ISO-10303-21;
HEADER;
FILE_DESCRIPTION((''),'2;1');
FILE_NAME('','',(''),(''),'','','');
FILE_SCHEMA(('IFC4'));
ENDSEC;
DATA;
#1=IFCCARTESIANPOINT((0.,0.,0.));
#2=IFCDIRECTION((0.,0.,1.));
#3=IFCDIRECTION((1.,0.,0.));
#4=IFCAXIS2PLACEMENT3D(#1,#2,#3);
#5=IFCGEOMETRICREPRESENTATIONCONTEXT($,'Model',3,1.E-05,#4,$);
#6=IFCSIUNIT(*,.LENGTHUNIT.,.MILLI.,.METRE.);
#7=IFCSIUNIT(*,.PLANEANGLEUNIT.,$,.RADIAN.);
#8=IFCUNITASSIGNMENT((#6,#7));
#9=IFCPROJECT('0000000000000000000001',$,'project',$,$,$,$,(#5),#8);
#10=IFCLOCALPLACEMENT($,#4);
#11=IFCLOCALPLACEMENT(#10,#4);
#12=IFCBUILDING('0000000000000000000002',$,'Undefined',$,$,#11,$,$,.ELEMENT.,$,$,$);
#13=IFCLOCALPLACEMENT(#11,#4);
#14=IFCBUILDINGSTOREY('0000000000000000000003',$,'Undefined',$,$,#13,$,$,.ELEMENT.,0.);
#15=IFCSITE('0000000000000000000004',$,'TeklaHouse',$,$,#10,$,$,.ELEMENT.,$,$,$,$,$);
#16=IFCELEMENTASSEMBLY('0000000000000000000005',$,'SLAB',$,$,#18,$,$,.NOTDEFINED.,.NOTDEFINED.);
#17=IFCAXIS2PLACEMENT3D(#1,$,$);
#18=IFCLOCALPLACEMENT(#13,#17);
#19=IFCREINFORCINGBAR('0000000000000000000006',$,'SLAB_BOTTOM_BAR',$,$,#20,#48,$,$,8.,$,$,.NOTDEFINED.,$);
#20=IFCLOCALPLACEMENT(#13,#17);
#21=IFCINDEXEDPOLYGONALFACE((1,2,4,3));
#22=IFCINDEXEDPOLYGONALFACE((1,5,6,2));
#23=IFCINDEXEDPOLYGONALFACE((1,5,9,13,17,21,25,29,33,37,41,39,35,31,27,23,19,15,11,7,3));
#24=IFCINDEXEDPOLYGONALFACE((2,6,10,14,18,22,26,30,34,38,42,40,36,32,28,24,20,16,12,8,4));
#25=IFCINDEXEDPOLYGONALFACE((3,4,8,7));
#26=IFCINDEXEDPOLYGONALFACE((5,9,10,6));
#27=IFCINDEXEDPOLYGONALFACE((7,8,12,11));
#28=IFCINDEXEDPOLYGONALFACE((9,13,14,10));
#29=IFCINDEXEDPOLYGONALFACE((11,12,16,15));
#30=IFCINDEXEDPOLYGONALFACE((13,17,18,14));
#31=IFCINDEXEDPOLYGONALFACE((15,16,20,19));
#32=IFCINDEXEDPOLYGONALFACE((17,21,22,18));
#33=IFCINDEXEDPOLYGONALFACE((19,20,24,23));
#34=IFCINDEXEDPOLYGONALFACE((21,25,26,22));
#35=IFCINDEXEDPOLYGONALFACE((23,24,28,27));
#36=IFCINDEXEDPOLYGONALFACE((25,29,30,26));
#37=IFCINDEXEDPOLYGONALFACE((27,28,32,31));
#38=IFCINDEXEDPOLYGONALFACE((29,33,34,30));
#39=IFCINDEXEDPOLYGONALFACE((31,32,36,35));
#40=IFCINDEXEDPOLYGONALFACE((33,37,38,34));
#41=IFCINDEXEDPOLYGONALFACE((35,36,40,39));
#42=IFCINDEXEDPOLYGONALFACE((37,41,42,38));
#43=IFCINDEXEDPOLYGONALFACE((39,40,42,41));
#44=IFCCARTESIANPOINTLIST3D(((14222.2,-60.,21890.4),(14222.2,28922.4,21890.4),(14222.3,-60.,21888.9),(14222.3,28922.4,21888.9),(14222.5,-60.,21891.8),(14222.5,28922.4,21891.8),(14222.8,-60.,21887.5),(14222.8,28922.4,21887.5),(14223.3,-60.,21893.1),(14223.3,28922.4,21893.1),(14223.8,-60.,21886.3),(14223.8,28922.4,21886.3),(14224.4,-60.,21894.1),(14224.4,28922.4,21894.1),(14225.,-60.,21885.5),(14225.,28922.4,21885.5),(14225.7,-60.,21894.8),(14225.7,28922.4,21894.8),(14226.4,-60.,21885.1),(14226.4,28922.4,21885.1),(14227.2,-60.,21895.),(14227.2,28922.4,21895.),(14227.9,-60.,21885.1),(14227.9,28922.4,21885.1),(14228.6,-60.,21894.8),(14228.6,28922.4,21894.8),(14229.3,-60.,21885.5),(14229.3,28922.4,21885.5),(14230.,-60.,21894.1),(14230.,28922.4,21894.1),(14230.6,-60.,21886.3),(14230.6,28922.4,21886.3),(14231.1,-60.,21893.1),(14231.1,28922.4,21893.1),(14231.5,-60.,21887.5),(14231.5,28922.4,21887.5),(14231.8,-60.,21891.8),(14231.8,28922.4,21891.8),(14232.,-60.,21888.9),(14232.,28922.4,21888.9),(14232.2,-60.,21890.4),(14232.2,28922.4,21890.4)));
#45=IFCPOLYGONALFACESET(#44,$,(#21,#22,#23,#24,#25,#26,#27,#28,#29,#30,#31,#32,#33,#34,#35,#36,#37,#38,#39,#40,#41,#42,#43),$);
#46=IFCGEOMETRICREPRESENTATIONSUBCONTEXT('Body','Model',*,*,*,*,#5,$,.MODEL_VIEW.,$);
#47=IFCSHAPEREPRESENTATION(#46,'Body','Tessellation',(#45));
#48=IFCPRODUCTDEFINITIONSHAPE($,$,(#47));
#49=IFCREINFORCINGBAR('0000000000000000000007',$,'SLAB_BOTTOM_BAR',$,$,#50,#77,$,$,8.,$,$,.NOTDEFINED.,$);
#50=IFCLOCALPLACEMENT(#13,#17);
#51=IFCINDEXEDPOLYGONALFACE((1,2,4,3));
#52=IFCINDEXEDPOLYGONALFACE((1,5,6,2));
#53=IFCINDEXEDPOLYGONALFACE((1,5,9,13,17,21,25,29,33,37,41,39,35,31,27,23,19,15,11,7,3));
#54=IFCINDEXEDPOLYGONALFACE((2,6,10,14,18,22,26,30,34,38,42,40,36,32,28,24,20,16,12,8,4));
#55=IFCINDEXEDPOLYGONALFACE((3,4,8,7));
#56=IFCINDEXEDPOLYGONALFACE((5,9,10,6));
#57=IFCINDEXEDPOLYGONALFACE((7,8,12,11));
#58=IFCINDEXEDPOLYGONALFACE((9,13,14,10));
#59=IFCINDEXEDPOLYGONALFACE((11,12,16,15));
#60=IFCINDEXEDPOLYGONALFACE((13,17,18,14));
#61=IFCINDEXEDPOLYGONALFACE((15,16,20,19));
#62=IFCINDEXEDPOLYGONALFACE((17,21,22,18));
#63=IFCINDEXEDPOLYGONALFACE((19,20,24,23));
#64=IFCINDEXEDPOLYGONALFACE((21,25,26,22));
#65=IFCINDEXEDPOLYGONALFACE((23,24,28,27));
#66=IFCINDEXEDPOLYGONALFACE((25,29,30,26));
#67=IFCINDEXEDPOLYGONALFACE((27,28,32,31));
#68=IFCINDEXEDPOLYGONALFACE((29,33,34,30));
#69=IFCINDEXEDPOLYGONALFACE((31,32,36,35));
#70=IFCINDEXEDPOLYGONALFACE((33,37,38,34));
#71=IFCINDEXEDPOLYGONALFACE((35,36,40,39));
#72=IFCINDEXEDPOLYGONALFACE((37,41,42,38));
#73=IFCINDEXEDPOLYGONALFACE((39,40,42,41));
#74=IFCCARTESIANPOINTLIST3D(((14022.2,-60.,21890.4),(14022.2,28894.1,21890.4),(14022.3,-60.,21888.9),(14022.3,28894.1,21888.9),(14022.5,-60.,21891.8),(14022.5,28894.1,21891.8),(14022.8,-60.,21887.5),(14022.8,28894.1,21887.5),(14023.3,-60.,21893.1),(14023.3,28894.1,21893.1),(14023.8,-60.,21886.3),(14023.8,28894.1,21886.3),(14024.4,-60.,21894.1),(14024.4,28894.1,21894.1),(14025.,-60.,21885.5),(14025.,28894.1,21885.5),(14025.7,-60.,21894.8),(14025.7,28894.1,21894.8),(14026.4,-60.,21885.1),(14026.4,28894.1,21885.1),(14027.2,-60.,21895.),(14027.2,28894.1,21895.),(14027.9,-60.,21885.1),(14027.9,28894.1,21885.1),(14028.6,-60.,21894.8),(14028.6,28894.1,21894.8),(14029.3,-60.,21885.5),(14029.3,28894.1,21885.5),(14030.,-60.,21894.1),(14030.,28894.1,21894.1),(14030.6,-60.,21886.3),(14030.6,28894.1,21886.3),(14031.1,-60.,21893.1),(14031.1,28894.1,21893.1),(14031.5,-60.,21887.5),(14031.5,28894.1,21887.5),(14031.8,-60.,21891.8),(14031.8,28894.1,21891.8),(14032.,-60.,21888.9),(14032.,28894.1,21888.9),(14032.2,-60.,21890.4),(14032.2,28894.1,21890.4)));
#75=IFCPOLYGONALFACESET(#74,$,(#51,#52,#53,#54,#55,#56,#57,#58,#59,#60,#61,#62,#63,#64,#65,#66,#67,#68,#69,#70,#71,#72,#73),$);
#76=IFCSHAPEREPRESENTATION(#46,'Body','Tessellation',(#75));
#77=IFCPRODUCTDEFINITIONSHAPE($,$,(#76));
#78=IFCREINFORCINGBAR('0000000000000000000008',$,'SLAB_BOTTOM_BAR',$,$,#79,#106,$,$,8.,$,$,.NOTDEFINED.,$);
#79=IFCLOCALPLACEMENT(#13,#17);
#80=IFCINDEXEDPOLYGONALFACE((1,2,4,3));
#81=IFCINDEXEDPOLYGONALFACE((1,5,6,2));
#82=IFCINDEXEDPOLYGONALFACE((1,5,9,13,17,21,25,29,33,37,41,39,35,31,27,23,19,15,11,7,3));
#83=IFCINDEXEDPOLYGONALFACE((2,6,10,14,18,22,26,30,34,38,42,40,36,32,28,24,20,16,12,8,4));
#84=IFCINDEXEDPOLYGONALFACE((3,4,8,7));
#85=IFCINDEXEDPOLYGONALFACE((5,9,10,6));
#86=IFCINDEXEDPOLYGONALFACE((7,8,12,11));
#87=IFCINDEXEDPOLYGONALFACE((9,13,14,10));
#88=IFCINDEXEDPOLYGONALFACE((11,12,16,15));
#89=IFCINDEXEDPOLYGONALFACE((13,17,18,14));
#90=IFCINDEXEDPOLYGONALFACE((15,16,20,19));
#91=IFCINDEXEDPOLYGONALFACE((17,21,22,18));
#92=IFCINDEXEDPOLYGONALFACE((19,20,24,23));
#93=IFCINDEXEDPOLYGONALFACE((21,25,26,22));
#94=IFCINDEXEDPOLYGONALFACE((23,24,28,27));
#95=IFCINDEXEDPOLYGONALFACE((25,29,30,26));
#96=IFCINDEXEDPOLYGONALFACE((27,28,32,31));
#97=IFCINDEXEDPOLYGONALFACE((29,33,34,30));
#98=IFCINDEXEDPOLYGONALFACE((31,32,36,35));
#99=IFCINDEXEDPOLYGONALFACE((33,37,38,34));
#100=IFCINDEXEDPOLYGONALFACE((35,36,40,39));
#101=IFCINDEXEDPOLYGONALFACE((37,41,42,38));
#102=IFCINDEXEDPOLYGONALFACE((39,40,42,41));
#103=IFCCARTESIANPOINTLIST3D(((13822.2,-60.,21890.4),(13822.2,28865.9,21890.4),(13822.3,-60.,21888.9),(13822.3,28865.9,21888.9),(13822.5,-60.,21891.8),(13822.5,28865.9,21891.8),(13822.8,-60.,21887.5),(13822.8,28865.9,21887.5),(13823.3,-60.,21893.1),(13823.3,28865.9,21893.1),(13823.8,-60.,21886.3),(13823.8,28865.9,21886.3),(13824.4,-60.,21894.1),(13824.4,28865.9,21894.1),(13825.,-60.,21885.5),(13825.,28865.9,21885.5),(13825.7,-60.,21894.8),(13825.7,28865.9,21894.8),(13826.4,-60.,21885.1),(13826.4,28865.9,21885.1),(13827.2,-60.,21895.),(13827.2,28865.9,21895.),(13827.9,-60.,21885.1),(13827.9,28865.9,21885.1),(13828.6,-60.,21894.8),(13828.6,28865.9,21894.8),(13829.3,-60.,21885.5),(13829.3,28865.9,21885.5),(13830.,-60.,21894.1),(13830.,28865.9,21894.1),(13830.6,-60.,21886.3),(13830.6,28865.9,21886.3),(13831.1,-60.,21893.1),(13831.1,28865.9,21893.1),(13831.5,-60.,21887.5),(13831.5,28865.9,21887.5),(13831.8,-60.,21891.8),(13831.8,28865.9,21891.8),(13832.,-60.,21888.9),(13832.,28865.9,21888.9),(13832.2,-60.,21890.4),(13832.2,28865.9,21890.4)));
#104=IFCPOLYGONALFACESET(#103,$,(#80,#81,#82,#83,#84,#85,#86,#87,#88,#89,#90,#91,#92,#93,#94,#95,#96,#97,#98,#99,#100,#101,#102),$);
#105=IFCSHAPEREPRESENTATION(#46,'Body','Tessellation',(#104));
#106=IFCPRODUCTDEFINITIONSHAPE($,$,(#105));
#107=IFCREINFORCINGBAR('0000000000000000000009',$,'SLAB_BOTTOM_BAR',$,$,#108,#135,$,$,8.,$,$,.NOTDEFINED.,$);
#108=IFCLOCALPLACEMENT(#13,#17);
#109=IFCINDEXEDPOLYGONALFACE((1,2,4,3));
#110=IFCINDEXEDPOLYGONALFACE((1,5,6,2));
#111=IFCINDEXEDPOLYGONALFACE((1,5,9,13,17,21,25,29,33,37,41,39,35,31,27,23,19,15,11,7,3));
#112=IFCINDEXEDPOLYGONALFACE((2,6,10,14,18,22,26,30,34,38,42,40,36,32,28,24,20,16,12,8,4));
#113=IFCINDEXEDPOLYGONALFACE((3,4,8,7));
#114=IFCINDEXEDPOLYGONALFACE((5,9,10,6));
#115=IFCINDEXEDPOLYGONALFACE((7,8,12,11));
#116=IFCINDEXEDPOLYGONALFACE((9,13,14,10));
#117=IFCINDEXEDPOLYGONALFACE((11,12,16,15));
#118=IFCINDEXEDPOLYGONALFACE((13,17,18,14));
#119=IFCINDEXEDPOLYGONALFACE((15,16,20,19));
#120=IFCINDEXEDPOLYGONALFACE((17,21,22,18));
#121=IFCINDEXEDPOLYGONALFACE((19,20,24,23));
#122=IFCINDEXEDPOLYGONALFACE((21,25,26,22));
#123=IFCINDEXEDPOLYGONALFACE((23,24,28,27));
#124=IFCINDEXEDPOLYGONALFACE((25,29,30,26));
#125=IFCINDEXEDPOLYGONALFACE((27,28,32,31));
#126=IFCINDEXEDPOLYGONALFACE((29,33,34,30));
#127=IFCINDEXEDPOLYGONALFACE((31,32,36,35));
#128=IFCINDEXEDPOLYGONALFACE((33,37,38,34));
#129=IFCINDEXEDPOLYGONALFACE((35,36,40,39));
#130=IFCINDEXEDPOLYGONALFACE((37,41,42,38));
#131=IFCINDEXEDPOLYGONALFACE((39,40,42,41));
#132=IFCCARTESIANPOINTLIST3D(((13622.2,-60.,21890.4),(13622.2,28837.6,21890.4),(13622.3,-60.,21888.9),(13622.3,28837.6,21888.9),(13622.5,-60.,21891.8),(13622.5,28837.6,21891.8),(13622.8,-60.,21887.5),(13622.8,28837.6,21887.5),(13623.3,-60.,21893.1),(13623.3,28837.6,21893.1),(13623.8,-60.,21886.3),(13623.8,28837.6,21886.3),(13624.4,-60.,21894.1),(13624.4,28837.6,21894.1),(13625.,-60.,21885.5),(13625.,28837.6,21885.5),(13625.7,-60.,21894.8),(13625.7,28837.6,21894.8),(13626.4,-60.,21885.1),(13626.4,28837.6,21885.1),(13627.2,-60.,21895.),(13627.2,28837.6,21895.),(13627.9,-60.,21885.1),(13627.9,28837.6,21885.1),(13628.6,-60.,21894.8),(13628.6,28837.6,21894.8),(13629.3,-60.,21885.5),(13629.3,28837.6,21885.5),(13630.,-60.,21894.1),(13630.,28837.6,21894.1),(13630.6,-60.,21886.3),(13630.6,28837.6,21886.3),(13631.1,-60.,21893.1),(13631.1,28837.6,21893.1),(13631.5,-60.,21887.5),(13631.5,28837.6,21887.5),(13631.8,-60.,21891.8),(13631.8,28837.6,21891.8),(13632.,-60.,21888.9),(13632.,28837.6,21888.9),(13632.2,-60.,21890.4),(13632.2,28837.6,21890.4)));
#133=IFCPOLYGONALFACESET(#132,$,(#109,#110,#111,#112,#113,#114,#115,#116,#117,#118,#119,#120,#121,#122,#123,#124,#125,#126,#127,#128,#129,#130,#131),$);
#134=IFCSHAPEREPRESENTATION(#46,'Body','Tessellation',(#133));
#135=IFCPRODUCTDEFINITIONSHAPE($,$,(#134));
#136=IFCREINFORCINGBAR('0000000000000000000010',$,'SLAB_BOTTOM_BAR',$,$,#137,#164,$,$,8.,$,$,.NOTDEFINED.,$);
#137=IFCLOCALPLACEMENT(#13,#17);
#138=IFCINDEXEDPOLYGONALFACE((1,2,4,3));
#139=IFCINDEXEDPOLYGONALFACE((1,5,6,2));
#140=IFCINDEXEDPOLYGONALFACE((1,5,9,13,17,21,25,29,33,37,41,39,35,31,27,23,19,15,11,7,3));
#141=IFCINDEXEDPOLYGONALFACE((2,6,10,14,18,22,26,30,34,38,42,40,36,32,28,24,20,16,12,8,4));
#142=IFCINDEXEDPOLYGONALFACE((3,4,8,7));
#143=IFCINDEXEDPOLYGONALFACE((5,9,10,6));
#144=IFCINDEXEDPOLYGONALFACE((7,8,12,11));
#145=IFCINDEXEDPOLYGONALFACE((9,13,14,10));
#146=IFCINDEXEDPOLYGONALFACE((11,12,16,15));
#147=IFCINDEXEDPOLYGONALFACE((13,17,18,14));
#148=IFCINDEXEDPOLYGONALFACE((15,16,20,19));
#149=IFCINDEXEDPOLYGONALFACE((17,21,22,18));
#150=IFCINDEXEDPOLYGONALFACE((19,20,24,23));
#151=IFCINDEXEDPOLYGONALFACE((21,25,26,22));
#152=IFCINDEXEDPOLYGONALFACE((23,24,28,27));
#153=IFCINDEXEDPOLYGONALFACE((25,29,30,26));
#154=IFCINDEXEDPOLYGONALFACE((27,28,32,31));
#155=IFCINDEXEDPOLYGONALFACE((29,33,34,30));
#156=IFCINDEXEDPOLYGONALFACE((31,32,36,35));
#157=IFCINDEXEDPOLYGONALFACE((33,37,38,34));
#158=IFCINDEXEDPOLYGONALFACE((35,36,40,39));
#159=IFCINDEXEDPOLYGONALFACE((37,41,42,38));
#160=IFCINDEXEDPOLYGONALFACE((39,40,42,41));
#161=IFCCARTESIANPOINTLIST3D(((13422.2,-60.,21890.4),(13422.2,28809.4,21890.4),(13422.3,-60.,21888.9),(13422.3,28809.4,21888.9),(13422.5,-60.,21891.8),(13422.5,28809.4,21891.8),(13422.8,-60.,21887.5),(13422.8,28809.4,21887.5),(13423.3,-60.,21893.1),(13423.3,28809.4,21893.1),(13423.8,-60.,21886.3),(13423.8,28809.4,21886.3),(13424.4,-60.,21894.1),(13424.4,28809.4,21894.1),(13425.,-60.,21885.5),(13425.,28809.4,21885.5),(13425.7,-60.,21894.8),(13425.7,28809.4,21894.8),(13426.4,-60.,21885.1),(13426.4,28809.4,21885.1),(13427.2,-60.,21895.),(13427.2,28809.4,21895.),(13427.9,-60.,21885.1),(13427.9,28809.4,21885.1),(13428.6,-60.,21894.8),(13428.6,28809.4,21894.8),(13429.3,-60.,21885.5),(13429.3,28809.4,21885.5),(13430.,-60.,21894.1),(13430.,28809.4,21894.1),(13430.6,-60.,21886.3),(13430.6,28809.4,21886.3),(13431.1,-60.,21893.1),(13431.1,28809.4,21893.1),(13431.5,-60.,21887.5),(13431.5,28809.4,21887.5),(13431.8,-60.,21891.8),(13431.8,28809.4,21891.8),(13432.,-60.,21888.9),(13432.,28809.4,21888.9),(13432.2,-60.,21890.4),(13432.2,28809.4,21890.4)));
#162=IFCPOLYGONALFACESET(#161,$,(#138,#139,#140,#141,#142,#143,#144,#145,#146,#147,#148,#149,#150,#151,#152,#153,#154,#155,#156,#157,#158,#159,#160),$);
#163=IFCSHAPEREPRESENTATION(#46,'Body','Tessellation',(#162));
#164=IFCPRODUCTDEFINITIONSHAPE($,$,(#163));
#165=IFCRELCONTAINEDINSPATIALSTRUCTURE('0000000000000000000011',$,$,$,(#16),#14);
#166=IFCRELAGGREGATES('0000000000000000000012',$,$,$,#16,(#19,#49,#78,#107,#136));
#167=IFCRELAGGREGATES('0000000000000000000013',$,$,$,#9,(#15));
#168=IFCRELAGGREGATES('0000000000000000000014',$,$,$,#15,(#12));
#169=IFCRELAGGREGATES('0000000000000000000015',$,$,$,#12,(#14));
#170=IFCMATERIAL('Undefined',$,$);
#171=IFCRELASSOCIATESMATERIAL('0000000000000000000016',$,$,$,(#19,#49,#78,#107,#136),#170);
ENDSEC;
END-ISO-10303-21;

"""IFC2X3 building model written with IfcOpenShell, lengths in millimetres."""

from ifc_helpers import new_model, entity, si_unit, frame, origin_with_axes, place, context, subcontext, project, spatial, source, transform, mapped, material, element, aggregate, save


model = new_model("IFC2X3")

# Units and contexts
model_context = context("Model", 3, precision=1e-05, world=origin_with_axes())
body_context = subcontext(model_context, "Body", "Model", "MODEL_VIEW")
ifc_project = project(units=[si_unit("LENGTHUNIT", "METRE", prefix="MILLI"), si_unit("PLANEANGLEUNIT", "RADIAN")], contexts=[model_context])

# Site, building, storey
site_placement = place(None, origin_with_axes())
site = spatial("IfcSite", under=ifc_project, at=site_placement, Name="TeklaHouse", CompositionType="ELEMENT")
building_placement = place(site_placement, origin_with_axes())
building = spatial("IfcBuilding", under=site, at=building_placement, Name="Undefined", CompositionType="ELEMENT")
storey_placement = place(building_placement, origin_with_axes())
storey = spatial("IfcBuildingStorey", under=building, at=storey_placement, Name="Undefined", CompositionType="ELEMENT", Elevation=0.0)

# Shared definitions
ifc_material_1 = material(Name="Undefined")

# Element assembly, reinforcing bars
assembly_1_placement = place(storey_placement, origin_with_axes())
assembly_1 = element("IfcElementAssembly", 1, at=assembly_1_placement, inside=storey, Name="SLAB", AssemblyPlace="NOTDEFINED", PredefinedType="NOTDEFINED")
shared_shape_1 = source(origin_with_axes(), body_context, "Body", "AdvancedSweptSolid", [
    entity("IfcSweptDiskSolid", entity("IfcTrimmedCurve", entity("IfcLine", entity("IfcCartesianPoint", [0.0, 0.0, 0.0]), entity("IfcVector", entity("IfcDirection", [1.0, 0.0, 0.0]), 1.0)), [entity("IfcParameterValue", 0.0)], [entity("IfcParameterValue", 28982.363359)], True, "PARAMETER"), 5.0, None, 0.0, 28982.4),
])
reinforcing_bar_1_placement = place(assembly_1_placement, frame((14227.2, -60.0, 21890.0), z_axis=(0.0, 0.0, 1.0), x_axis=(0.0, 1.0, 0.0)))
reinforcing_bar_1 = element("IfcReinforcingBar", 2, at=reinforcing_bar_1_placement, material=ifc_material_1, Name="SLAB_BOTTOM_BAR", BarRole="NOTDEFINED", NominalDiameter=8.0, context=body_context, shape_type="MappedRepresentation", body=[
    mapped(shared_shape_1, transform((0.0, 0.0, 0.0))),
])
shared_shape_2 = source(origin_with_axes(), body_context, "Body", "AdvancedSweptSolid", [
    entity("IfcSweptDiskSolid", entity("IfcTrimmedCurve", entity("IfcLine", entity("IfcCartesianPoint", [0.0, 0.0, 0.0]), entity("IfcVector", entity("IfcDirection", [1.0, 0.0, 0.0]), 1.0)), [entity("IfcParameterValue", 0.0)], [entity("IfcParameterValue", 28954.121248)], True, "PARAMETER"), 5.0, None, 0.0, 28954.1),
])
reinforcing_bar_2_placement = place(assembly_1_placement, frame((14027.2, -60.0, 21890.0), z_axis=(0.0, 0.0, 1.0), x_axis=(0.0, 1.0, 0.0)))
reinforcing_bar_2 = element("IfcReinforcingBar", 3, at=reinforcing_bar_2_placement, material=ifc_material_1, Name="SLAB_BOTTOM_BAR", BarRole="NOTDEFINED", NominalDiameter=8.0, context=body_context, shape_type="MappedRepresentation", body=[
    mapped(shared_shape_2, transform((0.0, 0.0, 0.0))),
])
shared_shape_3 = source(origin_with_axes(), body_context, "Body", "AdvancedSweptSolid", [
    entity("IfcSweptDiskSolid", entity("IfcTrimmedCurve", entity("IfcLine", entity("IfcCartesianPoint", [0.0, 0.0, 0.0]), entity("IfcVector", entity("IfcDirection", [1.0, 0.0, 0.0]), 1.0)), [entity("IfcParameterValue", 0.0)], [entity("IfcParameterValue", 28925.879138)], True, "PARAMETER"), 5.0, None, 0.0, 28925.9),
])
reinforcing_bar_3_placement = place(assembly_1_placement, frame((13827.2, -60.0, 21890.0), z_axis=(0.0, 0.0, 1.0), x_axis=(0.0, 1.0, 0.0)))
reinforcing_bar_3 = element("IfcReinforcingBar", 4, at=reinforcing_bar_3_placement, material=ifc_material_1, Name="SLAB_BOTTOM_BAR", BarRole="NOTDEFINED", NominalDiameter=8.0, context=body_context, shape_type="MappedRepresentation", body=[
    mapped(shared_shape_3, transform((0.0, 0.0, 0.0))),
])
shared_shape_4 = source(origin_with_axes(), body_context, "Body", "AdvancedSweptSolid", [
    entity("IfcSweptDiskSolid", entity("IfcTrimmedCurve", entity("IfcLine", entity("IfcCartesianPoint", [0.0, 0.0, 0.0]), entity("IfcVector", entity("IfcDirection", [1.0, 0.0, 0.0]), 1.0)), [entity("IfcParameterValue", 0.0)], [entity("IfcParameterValue", 28897.637027)], True, "PARAMETER"), 5.0, None, 0.0, 28897.6),
])
reinforcing_bar_4_placement = place(assembly_1_placement, frame((13627.2, -60.0, 21890.0), z_axis=(0.0, 0.0, 1.0), x_axis=(0.0, 1.0, 0.0)))
reinforcing_bar_4 = element("IfcReinforcingBar", 5, at=reinforcing_bar_4_placement, material=ifc_material_1, Name="SLAB_BOTTOM_BAR", BarRole="NOTDEFINED", NominalDiameter=8.0, context=body_context, shape_type="MappedRepresentation", body=[
    mapped(shared_shape_4, transform((0.0, 0.0, 0.0))),
])
shared_shape_5 = source(origin_with_axes(), body_context, "Body", "AdvancedSweptSolid", [
    entity("IfcSweptDiskSolid", entity("IfcTrimmedCurve", entity("IfcLine", entity("IfcCartesianPoint", [0.0, 0.0, 0.0]), entity("IfcVector", entity("IfcDirection", [1.0, 0.0, 0.0]), 1.0)), [entity("IfcParameterValue", 0.0)], [entity("IfcParameterValue", 28869.394916)], True, "PARAMETER"), 5.0, None, 0.0, 28869.4),
])
reinforcing_bar_5_placement = place(assembly_1_placement, frame((13427.2, -60.0, 21890.0), z_axis=(0.0, 0.0, 1.0), x_axis=(0.0, 1.0, 0.0)))
reinforcing_bar_5 = element("IfcReinforcingBar", 6, at=reinforcing_bar_5_placement, material=ifc_material_1, Name="SLAB_BOTTOM_BAR", BarRole="NOTDEFINED", NominalDiameter=8.0, context=body_context, shape_type="MappedRepresentation", body=[
    mapped(shared_shape_5, transform((0.0, 0.0, 0.0))),
])
aggregate(assembly_1, [reinforcing_bar_1, reinforcing_bar_2, reinforcing_bar_3, reinforcing_bar_4, reinforcing_bar_5])

save(model, "model.ifc")
